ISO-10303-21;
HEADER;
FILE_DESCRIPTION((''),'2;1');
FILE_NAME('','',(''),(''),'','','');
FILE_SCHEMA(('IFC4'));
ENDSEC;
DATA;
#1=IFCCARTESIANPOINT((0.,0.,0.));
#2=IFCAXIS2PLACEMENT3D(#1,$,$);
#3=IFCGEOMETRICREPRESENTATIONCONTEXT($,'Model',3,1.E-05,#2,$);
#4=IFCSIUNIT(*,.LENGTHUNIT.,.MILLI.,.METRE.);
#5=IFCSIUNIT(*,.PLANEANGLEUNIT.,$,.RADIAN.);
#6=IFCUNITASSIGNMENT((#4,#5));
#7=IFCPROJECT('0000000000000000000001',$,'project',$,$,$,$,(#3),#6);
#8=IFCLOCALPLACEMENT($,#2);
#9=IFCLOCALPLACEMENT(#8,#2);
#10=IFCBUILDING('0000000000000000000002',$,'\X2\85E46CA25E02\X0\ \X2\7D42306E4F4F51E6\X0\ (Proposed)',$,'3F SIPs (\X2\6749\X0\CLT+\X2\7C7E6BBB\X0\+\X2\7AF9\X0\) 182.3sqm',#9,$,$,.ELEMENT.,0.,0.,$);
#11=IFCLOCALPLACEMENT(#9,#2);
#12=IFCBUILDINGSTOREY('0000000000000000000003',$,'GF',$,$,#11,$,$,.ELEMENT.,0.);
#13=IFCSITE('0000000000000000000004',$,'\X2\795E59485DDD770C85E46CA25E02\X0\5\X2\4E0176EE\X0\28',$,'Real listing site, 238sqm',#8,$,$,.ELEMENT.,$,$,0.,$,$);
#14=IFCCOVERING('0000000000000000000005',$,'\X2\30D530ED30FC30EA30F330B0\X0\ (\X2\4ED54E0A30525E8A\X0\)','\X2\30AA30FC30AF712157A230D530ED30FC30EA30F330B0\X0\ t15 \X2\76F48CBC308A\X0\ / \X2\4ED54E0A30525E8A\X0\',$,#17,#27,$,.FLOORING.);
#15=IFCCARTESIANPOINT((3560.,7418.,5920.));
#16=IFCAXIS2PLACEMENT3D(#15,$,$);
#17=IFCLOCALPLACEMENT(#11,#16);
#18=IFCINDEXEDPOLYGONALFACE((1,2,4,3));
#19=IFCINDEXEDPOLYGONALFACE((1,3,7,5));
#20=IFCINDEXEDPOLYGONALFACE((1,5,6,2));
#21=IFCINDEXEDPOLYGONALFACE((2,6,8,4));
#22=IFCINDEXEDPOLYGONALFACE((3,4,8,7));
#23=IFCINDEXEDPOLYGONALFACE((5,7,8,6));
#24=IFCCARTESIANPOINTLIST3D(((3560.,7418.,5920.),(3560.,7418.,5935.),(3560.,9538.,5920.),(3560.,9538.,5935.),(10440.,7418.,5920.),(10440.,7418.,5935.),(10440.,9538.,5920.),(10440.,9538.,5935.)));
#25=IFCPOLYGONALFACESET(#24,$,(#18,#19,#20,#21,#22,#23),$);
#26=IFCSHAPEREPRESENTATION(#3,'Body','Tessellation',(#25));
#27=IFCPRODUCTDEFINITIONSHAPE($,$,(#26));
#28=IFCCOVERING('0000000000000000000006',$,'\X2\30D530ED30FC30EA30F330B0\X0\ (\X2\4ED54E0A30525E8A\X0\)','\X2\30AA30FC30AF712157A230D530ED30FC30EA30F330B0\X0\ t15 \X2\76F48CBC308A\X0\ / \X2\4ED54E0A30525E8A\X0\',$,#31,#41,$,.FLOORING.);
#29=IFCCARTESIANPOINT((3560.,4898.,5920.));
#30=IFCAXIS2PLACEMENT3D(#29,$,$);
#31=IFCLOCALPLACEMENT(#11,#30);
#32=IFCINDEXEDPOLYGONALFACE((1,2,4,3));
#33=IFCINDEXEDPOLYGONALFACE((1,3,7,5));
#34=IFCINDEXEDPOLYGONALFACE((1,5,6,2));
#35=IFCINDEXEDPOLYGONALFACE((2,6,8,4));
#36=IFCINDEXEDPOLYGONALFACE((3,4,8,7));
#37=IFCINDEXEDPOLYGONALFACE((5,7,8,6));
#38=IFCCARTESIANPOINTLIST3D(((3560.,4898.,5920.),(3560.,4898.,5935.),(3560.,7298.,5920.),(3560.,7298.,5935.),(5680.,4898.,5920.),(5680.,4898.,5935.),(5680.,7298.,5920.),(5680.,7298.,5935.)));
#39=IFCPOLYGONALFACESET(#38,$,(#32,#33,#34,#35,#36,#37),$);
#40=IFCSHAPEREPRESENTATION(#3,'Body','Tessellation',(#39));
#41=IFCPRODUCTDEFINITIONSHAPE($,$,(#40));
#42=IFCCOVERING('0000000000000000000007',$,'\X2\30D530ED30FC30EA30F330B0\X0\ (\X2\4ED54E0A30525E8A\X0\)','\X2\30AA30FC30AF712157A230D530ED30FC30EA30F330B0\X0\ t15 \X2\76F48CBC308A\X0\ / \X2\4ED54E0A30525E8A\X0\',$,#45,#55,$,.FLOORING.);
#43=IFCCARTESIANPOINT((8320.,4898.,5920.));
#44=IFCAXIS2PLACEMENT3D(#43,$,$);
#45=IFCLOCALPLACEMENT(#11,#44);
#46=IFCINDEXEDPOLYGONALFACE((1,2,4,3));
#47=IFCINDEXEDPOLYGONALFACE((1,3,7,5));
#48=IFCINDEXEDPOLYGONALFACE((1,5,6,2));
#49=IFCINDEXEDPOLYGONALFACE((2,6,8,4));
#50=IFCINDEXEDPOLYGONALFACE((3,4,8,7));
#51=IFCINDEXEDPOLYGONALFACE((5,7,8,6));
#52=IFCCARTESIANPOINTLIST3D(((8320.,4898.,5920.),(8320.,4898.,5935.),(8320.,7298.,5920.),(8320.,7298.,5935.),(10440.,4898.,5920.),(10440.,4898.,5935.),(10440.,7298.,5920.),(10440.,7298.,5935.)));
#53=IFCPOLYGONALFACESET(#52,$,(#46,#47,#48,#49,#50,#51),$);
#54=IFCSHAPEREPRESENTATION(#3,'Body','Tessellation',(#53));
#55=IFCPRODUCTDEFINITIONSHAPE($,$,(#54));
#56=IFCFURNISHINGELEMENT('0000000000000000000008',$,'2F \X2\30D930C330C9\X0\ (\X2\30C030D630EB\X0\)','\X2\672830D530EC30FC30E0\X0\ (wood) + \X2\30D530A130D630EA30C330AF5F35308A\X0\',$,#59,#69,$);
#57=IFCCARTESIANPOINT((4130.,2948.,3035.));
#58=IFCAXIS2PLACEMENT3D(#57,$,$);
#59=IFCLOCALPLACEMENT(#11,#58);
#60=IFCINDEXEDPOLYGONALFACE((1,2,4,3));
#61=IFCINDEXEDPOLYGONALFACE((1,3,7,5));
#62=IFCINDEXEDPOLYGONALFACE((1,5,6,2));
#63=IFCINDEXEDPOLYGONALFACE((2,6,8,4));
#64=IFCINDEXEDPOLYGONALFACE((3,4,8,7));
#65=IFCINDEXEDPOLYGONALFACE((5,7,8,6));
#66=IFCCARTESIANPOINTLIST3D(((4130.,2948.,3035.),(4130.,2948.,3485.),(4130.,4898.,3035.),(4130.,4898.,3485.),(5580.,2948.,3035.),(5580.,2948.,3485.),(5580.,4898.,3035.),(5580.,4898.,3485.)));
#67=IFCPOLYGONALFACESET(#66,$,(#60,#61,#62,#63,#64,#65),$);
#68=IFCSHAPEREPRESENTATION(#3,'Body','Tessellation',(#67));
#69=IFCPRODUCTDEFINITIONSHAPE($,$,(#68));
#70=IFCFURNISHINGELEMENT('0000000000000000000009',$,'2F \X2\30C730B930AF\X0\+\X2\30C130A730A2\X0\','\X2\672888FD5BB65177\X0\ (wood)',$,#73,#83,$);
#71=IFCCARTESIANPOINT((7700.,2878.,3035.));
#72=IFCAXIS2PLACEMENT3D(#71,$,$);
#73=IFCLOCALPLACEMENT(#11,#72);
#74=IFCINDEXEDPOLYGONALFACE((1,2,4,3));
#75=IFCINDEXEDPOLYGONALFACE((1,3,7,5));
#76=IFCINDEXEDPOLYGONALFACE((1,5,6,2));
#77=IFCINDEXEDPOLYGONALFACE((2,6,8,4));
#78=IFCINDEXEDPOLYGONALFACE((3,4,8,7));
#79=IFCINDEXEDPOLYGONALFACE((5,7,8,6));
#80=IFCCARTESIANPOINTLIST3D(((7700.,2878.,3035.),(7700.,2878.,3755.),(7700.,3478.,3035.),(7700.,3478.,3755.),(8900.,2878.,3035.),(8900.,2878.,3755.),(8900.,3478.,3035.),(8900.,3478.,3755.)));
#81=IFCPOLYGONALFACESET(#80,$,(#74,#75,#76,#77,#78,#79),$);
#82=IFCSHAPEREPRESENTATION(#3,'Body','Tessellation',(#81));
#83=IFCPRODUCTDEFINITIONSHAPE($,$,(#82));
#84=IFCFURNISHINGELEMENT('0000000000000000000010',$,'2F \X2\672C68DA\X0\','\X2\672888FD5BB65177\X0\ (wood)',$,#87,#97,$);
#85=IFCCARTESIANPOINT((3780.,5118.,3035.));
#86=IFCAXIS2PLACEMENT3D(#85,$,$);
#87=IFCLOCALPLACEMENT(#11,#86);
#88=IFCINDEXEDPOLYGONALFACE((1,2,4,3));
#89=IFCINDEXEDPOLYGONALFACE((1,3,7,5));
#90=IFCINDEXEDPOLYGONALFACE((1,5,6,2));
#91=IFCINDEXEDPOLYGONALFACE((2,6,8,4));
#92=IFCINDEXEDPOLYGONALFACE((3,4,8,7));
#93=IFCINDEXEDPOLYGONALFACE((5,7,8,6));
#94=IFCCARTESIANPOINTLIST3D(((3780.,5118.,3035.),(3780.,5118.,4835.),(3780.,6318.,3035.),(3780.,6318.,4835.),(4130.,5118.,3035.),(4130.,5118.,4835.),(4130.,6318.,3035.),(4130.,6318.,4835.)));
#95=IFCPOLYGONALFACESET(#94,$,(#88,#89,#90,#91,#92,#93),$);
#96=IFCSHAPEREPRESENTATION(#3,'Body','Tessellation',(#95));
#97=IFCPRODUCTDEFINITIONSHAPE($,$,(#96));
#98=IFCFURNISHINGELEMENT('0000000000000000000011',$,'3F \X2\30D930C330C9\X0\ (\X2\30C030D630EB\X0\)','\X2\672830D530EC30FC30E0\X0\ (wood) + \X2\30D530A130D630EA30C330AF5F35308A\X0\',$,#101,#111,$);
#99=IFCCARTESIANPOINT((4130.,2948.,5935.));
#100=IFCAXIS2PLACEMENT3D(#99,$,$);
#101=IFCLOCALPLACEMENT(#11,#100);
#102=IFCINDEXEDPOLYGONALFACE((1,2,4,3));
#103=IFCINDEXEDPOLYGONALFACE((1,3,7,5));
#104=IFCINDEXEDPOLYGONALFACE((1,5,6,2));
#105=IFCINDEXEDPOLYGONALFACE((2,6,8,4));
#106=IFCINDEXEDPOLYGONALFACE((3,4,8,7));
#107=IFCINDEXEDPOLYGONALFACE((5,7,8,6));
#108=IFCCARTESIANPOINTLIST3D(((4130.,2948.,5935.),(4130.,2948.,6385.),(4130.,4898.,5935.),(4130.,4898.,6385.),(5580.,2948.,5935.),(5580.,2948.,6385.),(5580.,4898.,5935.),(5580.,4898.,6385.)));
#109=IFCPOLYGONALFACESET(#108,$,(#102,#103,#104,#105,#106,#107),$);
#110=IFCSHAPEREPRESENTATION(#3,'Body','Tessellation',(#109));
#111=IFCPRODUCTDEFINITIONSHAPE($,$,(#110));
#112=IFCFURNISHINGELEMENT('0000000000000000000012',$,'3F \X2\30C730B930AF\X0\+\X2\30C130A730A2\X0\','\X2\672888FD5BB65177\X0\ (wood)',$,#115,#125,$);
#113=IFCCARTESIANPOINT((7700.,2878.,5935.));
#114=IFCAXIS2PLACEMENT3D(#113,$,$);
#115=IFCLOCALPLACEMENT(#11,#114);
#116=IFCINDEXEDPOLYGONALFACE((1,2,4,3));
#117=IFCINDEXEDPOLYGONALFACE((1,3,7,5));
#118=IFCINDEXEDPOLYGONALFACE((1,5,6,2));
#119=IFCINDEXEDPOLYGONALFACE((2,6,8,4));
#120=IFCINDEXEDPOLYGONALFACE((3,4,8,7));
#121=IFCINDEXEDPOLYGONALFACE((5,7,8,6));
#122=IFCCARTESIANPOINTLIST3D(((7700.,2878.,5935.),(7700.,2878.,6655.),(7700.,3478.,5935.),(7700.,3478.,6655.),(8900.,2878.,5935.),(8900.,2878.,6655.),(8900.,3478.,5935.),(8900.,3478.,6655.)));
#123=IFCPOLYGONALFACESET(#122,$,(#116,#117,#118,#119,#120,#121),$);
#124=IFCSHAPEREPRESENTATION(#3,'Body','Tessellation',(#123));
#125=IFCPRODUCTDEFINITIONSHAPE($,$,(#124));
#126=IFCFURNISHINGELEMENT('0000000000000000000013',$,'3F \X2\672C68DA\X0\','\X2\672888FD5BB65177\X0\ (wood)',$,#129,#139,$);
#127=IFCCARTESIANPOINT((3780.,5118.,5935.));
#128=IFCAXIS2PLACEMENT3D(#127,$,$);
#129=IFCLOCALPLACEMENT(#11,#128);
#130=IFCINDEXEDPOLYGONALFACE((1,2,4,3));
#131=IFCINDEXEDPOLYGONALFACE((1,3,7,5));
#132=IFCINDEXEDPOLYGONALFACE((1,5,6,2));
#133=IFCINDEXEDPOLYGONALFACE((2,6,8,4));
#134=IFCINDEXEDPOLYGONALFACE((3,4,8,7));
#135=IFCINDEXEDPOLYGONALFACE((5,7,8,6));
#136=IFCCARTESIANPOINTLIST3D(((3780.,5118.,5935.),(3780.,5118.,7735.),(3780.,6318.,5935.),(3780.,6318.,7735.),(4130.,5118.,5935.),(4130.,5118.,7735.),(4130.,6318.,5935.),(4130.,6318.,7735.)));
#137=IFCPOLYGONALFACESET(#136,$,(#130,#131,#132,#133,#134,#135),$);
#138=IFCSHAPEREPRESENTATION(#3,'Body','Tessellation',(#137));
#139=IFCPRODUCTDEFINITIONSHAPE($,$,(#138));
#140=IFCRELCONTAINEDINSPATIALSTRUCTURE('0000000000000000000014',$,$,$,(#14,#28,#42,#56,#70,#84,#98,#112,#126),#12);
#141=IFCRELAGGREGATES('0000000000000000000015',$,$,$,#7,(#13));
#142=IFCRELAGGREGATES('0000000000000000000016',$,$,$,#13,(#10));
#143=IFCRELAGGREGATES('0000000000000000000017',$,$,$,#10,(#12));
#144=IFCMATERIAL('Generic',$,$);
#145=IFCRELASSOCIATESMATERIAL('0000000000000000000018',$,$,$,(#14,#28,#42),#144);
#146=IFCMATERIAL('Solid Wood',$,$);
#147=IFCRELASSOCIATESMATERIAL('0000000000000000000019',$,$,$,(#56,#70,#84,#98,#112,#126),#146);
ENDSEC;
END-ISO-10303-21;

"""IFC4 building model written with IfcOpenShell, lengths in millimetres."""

from ifc_helpers import new_model, si_unit, frame, frame_2d, origin, place, context, project, spatial, rectangle, extrude, material, element, save


model = new_model("IFC4")

# Units and contexts
model_context = context("Model", 3, precision=1e-05, world=origin())
ifc_project = project(units=[si_unit("LENGTHUNIT", "METRE", prefix="MILLI"), si_unit("PLANEANGLEUNIT", "RADIAN")], contexts=[model_context])

# Site, building, storey
site_placement = place(None, origin())
site = spatial("IfcSite", under=ifc_project, at=site_placement, Name="神奈川県藤沢市5丁目28", ObjectType="Real listing site, 238sqm", CompositionType="ELEMENT", RefElevation=0.0)
building_placement = place(site_placement, origin())
building = spatial("IfcBuilding", under=site, at=building_placement, Name="藤沢市 終の住処 (Proposed)", ObjectType="3F SIPs (杉CLT+籾殻+竹) 182.3sqm", CompositionType="ELEMENT", ElevationOfRefHeight=0.0, ElevationOfTerrain=0.0)
storey_placement = place(building_placement, origin())
storey = spatial("IfcBuildingStorey", under=building, at=storey_placement, Name="GF", CompositionType="ELEMENT", Elevation=0.0)

# Shared definitions
ifc_material_1 = material(Name="Solid Wood")

# Shared definitions
ifc_material_2 = material(Name="Generic")

# Coverings
covering_1_placement = place(storey_placement, frame((3560.0, 7418.0, 5920.0)))
element("IfcCovering", 1, at=covering_1_placement, inside=storey, material=ifc_material_2, Name="フローリング (仕上げ床)", Description="オーク無垢フローリング t15 直貼り / 仕上げ床", PredefinedType="FLOORING", context=model_context, shape_type="SweptSolid", body=[
    extrude(rectangle(XDim=6880.0, YDim=2120.0, at=frame_2d((3440.0, 1060.0))), frame((3560.0, 7418.0, 5920.0)), (0.0, 0.0, 1.0), 15.0),
])
covering_2_placement = place(storey_placement, frame((3560.0, 4898.0, 5920.0)))
element("IfcCovering", 2, at=covering_2_placement, inside=storey, material=ifc_material_2, Name="フローリング (仕上げ床)", Description="オーク無垢フローリング t15 直貼り / 仕上げ床", PredefinedType="FLOORING", context=model_context, shape_type="SweptSolid", body=[
    extrude(rectangle(XDim=2120.0, YDim=2400.0, at=frame_2d((1060.0, 1200.0))), frame((3560.0, 4898.0, 5920.0)), (0.0, 0.0, 1.0), 15.0),
])
covering_3_placement = place(storey_placement, frame((8320.0, 4898.0, 5920.0)))
element("IfcCovering", 3, at=covering_3_placement, inside=storey, material=ifc_material_2, Name="フローリング (仕上げ床)", Description="オーク無垢フローリング t15 直貼り / 仕上げ床", PredefinedType="FLOORING", context=model_context, shape_type="SweptSolid", body=[
    extrude(rectangle(XDim=2120.0, YDim=2400.0, at=frame_2d((1060.0, 1200.0))), frame((8320.0, 4898.0, 5920.0)), (0.0, 0.0, 1.0), 15.0),
])

# Furnishing elements
furnishing_1_placement = place(storey_placement, frame((4130.0, 2948.0, 3035.0)))
element("IfcFurnishingElement", 4, at=furnishing_1_placement, inside=storey, material=ifc_material_1, Name="2F ベッド (ダブル)", Description="木フレーム (wood) + ファブリック張り", context=model_context, shape_type="SweptSolid", body=[
    extrude(rectangle(XDim=1450.0, YDim=1950.0, at=frame_2d((725.0, 975.0))), frame((4130.0, 2948.0, 3035.0)), (0.0, 0.0, 1.0), 450.0),
])
furnishing_2_placement = place(storey_placement, frame((7700.0, 2878.0, 3035.0)))
element("IfcFurnishingElement", 5, at=furnishing_2_placement, inside=storey, material=ifc_material_1, Name="2F デスク+チェア", Description="木製家具 (wood)", context=model_context, shape_type="SweptSolid", body=[
    extrude(rectangle(XDim=1200.0, YDim=600.0, at=frame_2d((600.0, 300.0))), frame((7700.0, 2878.0, 3035.0)), (0.0, 0.0, 1.0), 720.0),
])
furnishing_3_placement = place(storey_placement, frame((3780.0, 5118.0, 3035.0)))
element("IfcFurnishingElement", 6, at=furnishing_3_placement, inside=storey, material=ifc_material_1, Name="2F 本棚", Description="木製家具 (wood)", context=model_context, shape_type="SweptSolid", body=[
    extrude(rectangle(XDim=350.0, YDim=1200.0, at=frame_2d((175.0, 600.0))), frame((3780.0, 5118.0, 3035.0)), (0.0, 0.0, 1.0), 1800.0),
])
furnishing_4_placement = place(storey_placement, frame((4130.0, 2948.0, 5935.0)))
element("IfcFurnishingElement", 7, at=furnishing_4_placement, inside=storey, material=ifc_material_1, Name="3F ベッド (ダブル)", Description="木フレーム (wood) + ファブリック張り", context=model_context, shape_type="SweptSolid", body=[
    extrude(rectangle(XDim=1450.0, YDim=1950.0, at=frame_2d((725.0, 975.0))), frame((4130.0, 2948.0, 5935.0)), (0.0, 0.0, 1.0), 450.0),
])
furnishing_5_placement = place(storey_placement, frame((7700.0, 2878.0, 5935.0)))
element("IfcFurnishingElement", 8, at=furnishing_5_placement, inside=storey, material=ifc_material_1, Name="3F デスク+チェア", Description="木製家具 (wood)", context=model_context, shape_type="SweptSolid", body=[
    extrude(rectangle(XDim=1200.0, YDim=600.0, at=frame_2d((600.0, 300.0))), frame((7700.0, 2878.0, 5935.0)), (0.0, 0.0, 1.0), 720.0),
])
furnishing_6_placement = place(storey_placement, frame((3780.0, 5118.0, 5935.0)))
element("IfcFurnishingElement", 9, at=furnishing_6_placement, inside=storey, material=ifc_material_1, Name="3F 本棚", Description="木製家具 (wood)", context=model_context, shape_type="SweptSolid", body=[
    extrude(rectangle(XDim=350.0, YDim=1200.0, at=frame_2d((175.0, 600.0))), frame((3780.0, 5118.0, 5935.0)), (0.0, 0.0, 1.0), 1800.0),
])

save(model, "model.ifc")
